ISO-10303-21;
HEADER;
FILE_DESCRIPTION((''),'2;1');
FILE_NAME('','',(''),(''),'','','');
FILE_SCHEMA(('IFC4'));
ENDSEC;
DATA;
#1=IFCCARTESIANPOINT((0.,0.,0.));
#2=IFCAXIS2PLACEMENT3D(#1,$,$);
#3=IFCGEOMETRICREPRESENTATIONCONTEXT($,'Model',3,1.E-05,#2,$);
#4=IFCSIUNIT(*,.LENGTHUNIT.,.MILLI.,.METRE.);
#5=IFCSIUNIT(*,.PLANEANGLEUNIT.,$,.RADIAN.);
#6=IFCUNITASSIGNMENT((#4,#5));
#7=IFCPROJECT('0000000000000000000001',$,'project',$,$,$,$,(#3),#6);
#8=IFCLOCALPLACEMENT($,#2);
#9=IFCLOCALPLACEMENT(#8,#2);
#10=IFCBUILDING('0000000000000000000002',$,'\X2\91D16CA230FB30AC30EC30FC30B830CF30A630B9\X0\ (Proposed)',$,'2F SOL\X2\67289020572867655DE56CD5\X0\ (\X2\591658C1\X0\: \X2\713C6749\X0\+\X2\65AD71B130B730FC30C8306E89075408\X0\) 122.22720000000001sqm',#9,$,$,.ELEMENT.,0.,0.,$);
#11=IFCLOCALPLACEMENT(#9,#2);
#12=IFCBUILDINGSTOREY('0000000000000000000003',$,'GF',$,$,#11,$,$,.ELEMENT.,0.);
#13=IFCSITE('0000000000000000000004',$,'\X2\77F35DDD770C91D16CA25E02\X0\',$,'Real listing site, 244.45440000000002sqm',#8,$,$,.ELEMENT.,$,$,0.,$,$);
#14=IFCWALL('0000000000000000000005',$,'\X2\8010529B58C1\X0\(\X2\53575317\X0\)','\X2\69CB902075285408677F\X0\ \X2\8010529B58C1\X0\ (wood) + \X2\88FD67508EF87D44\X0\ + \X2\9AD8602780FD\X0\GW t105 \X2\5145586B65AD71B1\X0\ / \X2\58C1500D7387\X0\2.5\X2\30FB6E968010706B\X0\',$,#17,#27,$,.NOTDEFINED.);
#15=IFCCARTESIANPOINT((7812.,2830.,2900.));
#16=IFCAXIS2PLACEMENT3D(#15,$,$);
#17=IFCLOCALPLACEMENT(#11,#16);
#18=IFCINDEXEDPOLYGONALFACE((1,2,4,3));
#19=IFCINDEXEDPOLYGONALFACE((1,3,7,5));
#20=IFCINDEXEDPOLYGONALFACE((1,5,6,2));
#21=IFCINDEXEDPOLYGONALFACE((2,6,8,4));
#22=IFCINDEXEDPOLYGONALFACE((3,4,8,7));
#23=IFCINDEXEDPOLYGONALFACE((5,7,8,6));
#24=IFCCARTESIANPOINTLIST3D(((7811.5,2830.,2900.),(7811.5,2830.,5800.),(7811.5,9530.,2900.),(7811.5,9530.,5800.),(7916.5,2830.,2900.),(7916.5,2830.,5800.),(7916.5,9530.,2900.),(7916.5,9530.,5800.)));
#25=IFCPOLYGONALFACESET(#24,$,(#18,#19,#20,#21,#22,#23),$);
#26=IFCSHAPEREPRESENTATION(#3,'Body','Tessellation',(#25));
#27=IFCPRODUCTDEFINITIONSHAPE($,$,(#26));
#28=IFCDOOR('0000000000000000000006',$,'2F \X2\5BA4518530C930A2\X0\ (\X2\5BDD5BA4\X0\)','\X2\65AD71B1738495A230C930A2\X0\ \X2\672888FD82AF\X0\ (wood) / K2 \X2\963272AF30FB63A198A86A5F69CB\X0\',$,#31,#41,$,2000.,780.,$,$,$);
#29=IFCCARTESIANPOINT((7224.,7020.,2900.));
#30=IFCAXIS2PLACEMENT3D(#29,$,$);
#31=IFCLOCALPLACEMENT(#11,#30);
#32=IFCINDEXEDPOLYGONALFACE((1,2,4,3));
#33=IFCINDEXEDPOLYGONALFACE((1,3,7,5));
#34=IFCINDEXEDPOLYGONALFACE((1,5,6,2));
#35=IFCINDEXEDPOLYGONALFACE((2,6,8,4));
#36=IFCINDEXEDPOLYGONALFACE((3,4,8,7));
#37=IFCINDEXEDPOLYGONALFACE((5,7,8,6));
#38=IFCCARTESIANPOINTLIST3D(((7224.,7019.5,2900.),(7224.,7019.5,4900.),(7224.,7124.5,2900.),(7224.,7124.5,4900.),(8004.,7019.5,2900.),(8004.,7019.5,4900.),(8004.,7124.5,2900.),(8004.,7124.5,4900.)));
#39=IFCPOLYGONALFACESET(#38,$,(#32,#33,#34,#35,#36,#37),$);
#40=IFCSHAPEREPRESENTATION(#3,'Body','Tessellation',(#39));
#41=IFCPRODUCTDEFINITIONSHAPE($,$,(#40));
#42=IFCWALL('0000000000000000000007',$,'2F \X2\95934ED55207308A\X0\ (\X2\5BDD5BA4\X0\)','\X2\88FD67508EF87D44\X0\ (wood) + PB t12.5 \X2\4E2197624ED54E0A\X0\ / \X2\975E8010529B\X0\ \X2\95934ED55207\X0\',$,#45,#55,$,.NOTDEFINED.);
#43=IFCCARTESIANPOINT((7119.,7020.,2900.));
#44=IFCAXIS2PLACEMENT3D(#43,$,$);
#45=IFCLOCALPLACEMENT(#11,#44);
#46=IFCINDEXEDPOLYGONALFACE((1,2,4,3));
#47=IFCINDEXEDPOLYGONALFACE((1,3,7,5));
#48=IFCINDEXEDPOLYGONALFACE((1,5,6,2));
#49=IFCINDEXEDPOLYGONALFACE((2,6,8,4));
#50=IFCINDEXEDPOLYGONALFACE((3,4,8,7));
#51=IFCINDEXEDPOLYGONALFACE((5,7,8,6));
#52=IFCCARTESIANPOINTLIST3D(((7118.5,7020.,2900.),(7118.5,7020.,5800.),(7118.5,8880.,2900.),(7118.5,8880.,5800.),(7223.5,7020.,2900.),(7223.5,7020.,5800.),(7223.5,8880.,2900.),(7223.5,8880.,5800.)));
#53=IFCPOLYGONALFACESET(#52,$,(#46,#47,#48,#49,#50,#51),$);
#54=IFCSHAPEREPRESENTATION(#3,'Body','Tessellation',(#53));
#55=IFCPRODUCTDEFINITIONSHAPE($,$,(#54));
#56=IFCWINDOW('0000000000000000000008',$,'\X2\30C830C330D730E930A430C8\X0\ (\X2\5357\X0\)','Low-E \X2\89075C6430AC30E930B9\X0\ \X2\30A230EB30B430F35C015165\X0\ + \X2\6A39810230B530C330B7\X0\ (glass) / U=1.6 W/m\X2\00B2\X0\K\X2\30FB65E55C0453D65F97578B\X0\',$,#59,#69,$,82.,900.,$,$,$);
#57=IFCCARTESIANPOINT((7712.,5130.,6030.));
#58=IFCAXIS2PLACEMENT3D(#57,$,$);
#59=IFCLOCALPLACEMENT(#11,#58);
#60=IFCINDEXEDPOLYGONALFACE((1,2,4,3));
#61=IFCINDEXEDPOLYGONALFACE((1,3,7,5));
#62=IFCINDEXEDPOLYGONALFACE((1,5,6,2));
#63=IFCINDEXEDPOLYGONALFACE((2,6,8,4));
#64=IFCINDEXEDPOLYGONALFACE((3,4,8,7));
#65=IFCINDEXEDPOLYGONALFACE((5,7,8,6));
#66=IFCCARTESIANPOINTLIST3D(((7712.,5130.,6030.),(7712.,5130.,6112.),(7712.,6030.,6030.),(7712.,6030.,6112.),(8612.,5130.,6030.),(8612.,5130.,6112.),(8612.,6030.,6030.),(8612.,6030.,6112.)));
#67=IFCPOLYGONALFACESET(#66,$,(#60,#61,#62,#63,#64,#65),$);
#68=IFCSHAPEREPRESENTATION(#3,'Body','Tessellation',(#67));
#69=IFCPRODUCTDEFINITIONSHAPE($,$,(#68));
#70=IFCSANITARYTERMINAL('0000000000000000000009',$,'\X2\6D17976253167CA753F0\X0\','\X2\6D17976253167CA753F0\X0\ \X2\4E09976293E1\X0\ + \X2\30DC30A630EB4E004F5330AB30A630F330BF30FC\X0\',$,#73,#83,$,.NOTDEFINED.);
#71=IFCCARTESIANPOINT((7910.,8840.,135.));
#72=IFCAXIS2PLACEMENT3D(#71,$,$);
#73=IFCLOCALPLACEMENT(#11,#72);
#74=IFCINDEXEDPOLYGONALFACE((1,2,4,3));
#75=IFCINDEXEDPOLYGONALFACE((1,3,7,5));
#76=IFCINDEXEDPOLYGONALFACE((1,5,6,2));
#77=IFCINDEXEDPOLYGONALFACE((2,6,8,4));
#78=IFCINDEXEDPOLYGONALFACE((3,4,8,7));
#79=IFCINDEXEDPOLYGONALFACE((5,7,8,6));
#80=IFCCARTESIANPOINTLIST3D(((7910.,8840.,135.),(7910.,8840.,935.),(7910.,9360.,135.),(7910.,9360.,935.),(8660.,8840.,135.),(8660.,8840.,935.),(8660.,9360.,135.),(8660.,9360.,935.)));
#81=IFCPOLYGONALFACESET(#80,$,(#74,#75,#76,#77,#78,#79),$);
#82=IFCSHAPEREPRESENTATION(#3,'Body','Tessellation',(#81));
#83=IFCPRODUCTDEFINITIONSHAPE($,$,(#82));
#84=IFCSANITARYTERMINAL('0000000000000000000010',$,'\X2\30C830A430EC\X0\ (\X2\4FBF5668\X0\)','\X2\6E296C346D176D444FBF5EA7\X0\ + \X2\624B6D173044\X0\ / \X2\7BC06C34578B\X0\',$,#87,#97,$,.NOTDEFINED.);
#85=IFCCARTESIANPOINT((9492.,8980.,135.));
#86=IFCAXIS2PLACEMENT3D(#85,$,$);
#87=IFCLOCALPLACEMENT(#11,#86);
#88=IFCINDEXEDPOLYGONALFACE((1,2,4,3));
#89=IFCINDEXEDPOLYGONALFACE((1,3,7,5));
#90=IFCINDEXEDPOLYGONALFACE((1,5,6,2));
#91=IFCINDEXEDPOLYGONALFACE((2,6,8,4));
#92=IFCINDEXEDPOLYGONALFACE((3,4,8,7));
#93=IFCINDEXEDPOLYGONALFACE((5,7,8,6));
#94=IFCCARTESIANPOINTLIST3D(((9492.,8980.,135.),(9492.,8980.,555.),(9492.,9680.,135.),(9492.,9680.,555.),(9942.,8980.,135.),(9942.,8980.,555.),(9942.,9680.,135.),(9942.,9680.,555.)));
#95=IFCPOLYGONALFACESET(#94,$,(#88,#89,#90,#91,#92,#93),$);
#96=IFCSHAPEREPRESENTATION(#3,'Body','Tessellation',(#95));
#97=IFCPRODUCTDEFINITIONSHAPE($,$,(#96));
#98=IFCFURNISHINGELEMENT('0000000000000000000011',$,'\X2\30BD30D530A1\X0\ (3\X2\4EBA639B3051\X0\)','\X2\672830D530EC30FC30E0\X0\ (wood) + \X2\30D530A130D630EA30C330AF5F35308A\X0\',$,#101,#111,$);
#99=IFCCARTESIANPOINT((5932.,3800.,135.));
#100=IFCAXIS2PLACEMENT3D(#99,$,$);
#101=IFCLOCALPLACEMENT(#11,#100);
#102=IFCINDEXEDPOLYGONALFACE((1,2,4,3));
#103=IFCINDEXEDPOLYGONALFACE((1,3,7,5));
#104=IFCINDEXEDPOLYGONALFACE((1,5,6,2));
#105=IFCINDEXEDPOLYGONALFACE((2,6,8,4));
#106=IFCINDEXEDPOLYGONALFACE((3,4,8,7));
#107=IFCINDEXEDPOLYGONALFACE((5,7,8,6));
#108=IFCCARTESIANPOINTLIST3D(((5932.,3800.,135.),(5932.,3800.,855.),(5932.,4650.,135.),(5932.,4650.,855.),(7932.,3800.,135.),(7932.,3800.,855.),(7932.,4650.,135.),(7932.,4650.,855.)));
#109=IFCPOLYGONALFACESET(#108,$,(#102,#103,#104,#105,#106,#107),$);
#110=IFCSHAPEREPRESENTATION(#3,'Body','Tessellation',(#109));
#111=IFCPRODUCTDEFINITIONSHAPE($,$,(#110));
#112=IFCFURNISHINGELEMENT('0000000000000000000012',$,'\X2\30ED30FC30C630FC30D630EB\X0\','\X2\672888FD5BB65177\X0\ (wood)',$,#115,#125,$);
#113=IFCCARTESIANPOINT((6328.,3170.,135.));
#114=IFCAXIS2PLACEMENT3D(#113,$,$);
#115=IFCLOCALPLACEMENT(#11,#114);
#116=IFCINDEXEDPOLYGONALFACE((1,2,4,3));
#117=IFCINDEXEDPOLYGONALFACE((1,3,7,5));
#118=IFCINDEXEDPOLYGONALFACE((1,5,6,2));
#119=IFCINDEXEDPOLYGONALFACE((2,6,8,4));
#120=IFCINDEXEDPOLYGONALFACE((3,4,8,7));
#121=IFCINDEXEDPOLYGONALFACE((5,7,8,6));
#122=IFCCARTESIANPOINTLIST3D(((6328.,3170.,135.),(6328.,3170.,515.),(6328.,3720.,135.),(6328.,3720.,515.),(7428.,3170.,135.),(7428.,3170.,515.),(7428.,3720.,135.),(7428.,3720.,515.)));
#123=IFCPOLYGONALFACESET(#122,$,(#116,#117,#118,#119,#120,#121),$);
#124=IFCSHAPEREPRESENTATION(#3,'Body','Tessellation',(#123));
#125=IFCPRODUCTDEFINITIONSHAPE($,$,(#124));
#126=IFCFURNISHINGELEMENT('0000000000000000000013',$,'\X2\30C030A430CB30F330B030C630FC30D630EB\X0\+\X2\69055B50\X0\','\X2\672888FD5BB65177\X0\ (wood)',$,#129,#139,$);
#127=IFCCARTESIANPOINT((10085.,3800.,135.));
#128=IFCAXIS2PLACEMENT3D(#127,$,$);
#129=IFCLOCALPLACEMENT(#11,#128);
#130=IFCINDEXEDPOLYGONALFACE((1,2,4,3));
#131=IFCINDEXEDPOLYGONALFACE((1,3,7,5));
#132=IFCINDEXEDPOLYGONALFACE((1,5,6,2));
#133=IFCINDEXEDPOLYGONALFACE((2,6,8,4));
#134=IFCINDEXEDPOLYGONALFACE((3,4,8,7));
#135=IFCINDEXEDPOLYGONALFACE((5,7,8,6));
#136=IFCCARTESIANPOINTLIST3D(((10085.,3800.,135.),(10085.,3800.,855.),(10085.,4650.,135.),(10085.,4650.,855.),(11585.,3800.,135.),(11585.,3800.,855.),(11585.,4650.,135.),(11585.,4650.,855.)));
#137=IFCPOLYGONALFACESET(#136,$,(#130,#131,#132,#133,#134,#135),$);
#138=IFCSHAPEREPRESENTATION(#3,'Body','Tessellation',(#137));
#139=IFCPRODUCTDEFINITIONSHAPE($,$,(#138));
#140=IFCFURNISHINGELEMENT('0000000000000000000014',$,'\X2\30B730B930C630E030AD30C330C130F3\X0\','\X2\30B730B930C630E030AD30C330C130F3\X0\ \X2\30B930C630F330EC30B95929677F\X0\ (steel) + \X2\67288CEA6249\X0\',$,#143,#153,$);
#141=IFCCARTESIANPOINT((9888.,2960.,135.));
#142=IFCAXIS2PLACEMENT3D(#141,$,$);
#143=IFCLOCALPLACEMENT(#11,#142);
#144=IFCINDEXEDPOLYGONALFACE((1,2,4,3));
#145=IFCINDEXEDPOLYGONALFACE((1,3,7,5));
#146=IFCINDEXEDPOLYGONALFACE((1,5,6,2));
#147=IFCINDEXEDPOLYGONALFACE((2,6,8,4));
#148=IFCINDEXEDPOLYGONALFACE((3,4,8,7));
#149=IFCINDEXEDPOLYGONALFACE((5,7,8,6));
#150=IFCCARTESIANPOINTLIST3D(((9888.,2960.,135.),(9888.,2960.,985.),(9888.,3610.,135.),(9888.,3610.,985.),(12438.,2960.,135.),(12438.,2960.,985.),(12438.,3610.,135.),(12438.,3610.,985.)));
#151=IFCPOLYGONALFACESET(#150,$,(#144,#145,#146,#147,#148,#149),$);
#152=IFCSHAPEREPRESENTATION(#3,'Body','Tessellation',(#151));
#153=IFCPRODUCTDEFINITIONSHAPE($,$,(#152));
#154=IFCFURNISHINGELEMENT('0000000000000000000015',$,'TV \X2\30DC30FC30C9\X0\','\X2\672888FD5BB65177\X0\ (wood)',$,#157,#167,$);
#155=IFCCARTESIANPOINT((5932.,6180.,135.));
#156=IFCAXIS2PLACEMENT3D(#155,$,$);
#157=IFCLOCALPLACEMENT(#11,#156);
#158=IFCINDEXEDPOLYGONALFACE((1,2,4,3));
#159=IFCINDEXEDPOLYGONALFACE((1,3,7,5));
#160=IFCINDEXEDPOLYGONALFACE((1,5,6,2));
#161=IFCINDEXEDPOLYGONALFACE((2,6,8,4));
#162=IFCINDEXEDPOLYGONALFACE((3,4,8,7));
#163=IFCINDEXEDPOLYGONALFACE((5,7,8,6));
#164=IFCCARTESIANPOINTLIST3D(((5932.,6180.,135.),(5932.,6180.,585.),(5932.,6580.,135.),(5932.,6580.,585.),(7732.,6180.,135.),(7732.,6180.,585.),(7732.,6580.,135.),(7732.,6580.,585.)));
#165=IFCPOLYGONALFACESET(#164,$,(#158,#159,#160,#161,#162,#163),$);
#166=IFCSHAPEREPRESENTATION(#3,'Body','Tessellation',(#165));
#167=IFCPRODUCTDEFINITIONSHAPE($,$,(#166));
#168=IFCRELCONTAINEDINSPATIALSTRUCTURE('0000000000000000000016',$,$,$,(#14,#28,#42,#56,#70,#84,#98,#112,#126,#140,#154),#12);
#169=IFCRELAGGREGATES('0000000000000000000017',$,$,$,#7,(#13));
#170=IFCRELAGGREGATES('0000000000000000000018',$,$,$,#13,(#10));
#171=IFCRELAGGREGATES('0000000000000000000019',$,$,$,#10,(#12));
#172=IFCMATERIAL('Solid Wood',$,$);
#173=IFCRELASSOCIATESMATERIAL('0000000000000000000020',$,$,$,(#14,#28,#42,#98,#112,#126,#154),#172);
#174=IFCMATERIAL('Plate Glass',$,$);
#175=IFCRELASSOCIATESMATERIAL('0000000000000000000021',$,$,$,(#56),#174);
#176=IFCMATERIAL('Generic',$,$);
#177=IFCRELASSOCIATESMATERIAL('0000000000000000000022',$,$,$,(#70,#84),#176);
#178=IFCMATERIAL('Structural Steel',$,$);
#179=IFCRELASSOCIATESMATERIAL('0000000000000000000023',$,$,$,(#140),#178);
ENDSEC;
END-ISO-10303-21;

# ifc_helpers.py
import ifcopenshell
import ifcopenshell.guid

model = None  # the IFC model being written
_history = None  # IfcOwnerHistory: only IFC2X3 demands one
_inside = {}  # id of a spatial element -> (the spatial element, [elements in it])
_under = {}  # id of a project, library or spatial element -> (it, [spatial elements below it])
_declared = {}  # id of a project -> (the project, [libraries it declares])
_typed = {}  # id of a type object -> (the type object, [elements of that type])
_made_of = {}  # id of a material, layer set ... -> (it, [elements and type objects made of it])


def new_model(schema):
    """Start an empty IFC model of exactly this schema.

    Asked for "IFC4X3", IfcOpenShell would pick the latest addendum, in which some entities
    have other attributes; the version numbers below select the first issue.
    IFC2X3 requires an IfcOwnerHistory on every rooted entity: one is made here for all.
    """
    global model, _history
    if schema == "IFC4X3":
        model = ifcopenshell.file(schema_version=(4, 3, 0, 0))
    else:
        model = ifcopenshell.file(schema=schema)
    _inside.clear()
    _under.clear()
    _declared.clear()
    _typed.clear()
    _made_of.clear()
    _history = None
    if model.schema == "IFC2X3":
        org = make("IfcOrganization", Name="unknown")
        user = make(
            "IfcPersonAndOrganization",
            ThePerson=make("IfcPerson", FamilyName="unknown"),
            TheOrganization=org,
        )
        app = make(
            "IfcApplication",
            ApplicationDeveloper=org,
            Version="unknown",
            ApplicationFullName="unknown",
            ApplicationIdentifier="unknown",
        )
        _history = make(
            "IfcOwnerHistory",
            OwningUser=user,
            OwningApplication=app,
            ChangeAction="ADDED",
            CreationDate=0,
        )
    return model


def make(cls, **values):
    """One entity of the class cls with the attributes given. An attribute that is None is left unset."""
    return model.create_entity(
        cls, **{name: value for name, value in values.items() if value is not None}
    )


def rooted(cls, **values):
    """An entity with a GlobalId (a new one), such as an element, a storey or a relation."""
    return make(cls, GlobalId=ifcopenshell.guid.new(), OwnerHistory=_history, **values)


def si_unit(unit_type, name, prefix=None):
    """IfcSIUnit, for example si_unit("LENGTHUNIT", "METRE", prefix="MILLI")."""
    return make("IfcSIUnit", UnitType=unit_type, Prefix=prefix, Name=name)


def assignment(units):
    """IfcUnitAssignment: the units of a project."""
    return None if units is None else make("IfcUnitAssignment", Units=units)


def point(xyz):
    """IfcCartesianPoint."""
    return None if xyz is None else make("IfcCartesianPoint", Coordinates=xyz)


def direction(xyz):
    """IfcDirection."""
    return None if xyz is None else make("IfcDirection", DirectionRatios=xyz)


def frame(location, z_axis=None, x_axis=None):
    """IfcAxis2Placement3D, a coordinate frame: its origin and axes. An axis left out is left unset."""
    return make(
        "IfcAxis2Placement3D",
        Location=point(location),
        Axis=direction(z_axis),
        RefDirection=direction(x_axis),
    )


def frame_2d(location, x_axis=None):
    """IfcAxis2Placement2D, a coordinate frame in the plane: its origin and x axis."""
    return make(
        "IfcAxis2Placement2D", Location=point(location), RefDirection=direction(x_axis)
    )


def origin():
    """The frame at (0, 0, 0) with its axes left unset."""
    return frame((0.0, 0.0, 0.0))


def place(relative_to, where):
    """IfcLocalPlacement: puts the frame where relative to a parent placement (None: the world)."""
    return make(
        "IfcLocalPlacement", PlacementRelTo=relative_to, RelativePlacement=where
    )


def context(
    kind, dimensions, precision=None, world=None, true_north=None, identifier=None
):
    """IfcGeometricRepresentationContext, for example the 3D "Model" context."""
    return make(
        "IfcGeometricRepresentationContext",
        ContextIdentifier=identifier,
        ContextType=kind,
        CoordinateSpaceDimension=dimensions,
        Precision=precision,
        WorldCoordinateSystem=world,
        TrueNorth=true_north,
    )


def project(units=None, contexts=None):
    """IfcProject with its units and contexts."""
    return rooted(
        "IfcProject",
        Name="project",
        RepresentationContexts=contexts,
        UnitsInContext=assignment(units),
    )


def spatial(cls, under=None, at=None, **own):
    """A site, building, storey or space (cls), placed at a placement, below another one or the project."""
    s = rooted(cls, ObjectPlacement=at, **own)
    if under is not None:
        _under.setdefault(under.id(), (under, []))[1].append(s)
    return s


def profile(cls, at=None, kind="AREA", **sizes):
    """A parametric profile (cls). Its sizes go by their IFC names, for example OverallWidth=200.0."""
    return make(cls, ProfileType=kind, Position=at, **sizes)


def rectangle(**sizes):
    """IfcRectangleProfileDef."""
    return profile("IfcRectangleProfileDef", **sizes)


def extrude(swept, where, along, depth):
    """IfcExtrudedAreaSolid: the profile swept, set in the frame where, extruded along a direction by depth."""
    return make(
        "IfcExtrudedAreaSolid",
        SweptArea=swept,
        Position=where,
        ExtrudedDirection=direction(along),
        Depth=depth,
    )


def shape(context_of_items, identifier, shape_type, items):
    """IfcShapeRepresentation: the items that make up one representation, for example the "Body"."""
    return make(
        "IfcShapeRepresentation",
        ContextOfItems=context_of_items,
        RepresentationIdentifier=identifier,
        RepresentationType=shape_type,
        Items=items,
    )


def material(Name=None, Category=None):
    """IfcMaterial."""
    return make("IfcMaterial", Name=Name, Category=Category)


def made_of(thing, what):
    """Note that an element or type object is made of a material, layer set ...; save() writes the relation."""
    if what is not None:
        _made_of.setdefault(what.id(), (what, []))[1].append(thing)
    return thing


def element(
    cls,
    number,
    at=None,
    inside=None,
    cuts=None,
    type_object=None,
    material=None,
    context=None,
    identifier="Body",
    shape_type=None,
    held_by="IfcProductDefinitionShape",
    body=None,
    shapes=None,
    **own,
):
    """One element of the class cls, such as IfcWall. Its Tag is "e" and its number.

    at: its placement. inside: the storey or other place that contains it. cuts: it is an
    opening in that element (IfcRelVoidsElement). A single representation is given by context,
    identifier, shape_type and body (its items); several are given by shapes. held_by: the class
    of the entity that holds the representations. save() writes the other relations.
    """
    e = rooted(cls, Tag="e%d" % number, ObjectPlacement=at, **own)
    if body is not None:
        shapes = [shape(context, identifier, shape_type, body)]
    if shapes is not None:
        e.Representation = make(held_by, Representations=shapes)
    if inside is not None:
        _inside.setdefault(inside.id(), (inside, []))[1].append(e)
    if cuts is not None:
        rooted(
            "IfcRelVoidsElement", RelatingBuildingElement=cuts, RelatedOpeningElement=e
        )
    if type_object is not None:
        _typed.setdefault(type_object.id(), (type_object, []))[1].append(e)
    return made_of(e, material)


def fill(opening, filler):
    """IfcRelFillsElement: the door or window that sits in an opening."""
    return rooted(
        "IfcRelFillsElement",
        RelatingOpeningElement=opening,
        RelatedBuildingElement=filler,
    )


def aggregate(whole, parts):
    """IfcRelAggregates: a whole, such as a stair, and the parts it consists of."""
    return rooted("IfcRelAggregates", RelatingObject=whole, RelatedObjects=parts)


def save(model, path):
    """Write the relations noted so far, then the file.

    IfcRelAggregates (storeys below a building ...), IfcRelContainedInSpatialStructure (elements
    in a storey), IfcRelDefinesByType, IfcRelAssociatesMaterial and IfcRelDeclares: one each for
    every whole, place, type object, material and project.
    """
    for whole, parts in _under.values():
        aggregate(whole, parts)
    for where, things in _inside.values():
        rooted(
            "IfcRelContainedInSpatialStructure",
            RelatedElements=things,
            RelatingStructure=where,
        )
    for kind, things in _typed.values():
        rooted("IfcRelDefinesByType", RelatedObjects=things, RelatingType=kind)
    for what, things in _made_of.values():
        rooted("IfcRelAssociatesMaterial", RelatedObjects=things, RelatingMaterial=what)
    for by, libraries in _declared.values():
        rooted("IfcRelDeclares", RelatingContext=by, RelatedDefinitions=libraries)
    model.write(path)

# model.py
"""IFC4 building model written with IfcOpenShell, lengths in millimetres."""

from ifc_helpers import new_model, si_unit, frame, frame_2d, origin, place, context, project, spatial, rectangle, extrude, material, element, fill, save


model = new_model("IFC4")

# Units and contexts
model_context = context("Model", 3, precision=1e-05, world=origin())
ifc_project = project(units=[si_unit("LENGTHUNIT", "METRE", prefix="MILLI"), si_unit("PLANEANGLEUNIT", "RADIAN")], contexts=[model_context])

# Site, building, storey
site_placement = place(None, origin())
site = spatial("IfcSite", under=ifc_project, at=site_placement, Name="石川県金沢市", ObjectType="Real listing site, 244.45440000000002sqm", CompositionType="ELEMENT", RefElevation=0.0)
building_placement = place(site_placement, origin())
building = spatial("IfcBuilding", under=site, at=building_placement, Name="金沢・ガレージハウス (Proposed)", ObjectType="2F SOL木造在来工法 (外壁: 焼杉+断熱シートの複合) 122.22720000000001sqm", CompositionType="ELEMENT", ElevationOfRefHeight=0.0, ElevationOfTerrain=0.0)
storey_placement = place(building_placement, origin())
storey = spatial("IfcBuildingStorey", under=building, at=storey_placement, Name="GF", CompositionType="ELEMENT", Elevation=0.0)

# Shared definitions
ifc_material_1 = material(Name="Solid Wood")

# Wall, opening, door
wall_1_placement = place(storey_placement, frame((7812.0, 2830.0, 2900.0)))
wall_1 = element("IfcWall", 1, at=wall_1_placement, inside=storey, material=ifc_material_1, Name="耐力壁(南北)", Description="構造用合板 耐力壁 (wood) + 製材軸組 + 高性能GW t105 充填断熱 / 壁倍率2.5・準耐火", PredefinedType="NOTDEFINED", context=model_context, shape_type="SweptSolid", body=[
    extrude(rectangle(XDim=105.0, YDim=6700.0, at=frame_2d((52.0, 3350.0))), frame((7812.0, 2830.0, 2900.0)), (0.0, 0.0, 1.0), 2900.0),
])
opening_1_placement = place(storey_placement, frame((7224.0, 7020.0, 2900.0)))
opening_1 = element("IfcOpeningElement", 2, at=opening_1_placement, cuts=wall_1, PredefinedType="NOTDEFINED", context=model_context, shape_type="SweptSolid", body=[
    extrude(rectangle(XDim=780.0, YDim=105.0, at=frame_2d((390.0, 52.0))), frame((7224.0, 7020.0, 2900.0)), (0.0, 0.0, 1.0), 2000.0),
])
door_1_placement = place(storey_placement, frame((7224.0, 7020.0, 2900.0)))
door_1 = element("IfcDoor", 3, at=door_1_placement, inside=storey, material=ifc_material_1, Name="2F 室内ドア (寝室)", Description="断熱玄関ドア 木製芯 (wood) / K2 防犯・採風機構", OverallHeight=2000.0, OverallWidth=780.0, context=model_context, shape_type="SweptSolid", body=[
    extrude(rectangle(XDim=780.0, YDim=105.0, at=frame_2d((390.0, 52.0))), frame((7224.0, 7020.0, 2900.0)), (0.0, 0.0, 1.0), 2000.0),
])
fill(opening_1, door_1)

# Wall
wall_2_placement = place(storey_placement, frame((7119.0, 7020.0, 2900.0)))
element("IfcWall", 4, at=wall_2_placement, inside=storey, material=ifc_material_1, Name="2F 間仕切り (寝室)", Description="製材軸組 (wood) + PB t12.5 両面仕上 / 非耐力 間仕切", PredefinedType="NOTDEFINED", context=model_context, shape_type="SweptSolid", body=[
    extrude(rectangle(XDim=105.0, YDim=1860.0, at=frame_2d((52.0, 930.0))), frame((7119.0, 7020.0, 2900.0)), (0.0, 0.0, 1.0), 2900.0),
])

# Window
ifc_material_2 = material(Name="Plate Glass")
window_placement = place(storey_placement, frame((7712.0, 5130.0, 6030.0)))
element("IfcWindow", 5, at=window_placement, inside=storey, material=ifc_material_2, Name="トップライト (南)", Description="Low-E 複層ガラス アルゴン封入 + 樹脂サッシ (glass) / U=1.6 W/m²K・日射取得型", OverallHeight=82.0, OverallWidth=900.0, context=model_context, shape_type="SweptSolid", body=[
    extrude(rectangle(XDim=900.0, YDim=900.0, at=frame_2d((450.0, 450.0))), frame((7712.0, 5130.0, 6030.0)), (0.0, 0.0, 1.0), 82.0),
])

# Sanitary terminals
ifc_material_3 = material(Name="Generic")
sanitary_terminal_1_placement = place(storey_placement, frame((7910.0, 8840.0, 135.0)))
element("IfcSanitaryTerminal", 6, at=sanitary_terminal_1_placement, inside=storey, material=ifc_material_3, Name="洗面化粧台", Description="洗面化粧台 三面鏡 + ボウル一体カウンター", PredefinedType="NOTDEFINED", context=model_context, shape_type="SweptSolid", body=[
    extrude(rectangle(XDim=750.0, YDim=520.0, at=frame_2d((375.0, 260.0))), frame((7910.0, 8840.0, 135.0)), (0.0, 0.0, 1.0), 800.0),
])
sanitary_terminal_2_placement = place(storey_placement, frame((9492.0, 8980.0, 135.0)))
element("IfcSanitaryTerminal", 7, at=sanitary_terminal_2_placement, inside=storey, material=ifc_material_3, Name="トイレ (便器)", Description="温水洗浄便座 + 手洗い / 節水型", PredefinedType="NOTDEFINED", context=model_context, shape_type="SweptSolid", body=[
    extrude(rectangle(XDim=450.0, YDim=700.0, at=frame_2d((225.0, 350.0))), frame((9492.0, 8980.0, 135.0)), (0.0, 0.0, 1.0), 420.0),
])

# Furnishing elements
furnishing_1_placement = place(storey_placement, frame((5932.0, 3800.0, 135.0)))
element("IfcFurnishingElement", 8, at=furnishing_1_placement, inside=storey, material=ifc_material_1, Name="ソファ (3人掛け)", Description="木フレーム (wood) + ファブリック張り", context=model_context, shape_type="SweptSolid", body=[
    extrude(rectangle(XDim=2000.0, YDim=850.0, at=frame_2d((1000.0, 425.0))), frame((5932.0, 3800.0, 135.0)), (0.0, 0.0, 1.0), 720.0),
])
furnishing_2_placement = place(storey_placement, frame((6328.0, 3170.0, 135.0)))
element("IfcFurnishingElement", 9, at=furnishing_2_placement, inside=storey, material=ifc_material_1, Name="ローテーブル", Description="木製家具 (wood)", context=model_context, shape_type="SweptSolid", body=[
    extrude(rectangle(XDim=1100.0, YDim=550.0, at=frame_2d((550.0, 275.0))), frame((6328.0, 3170.0, 135.0)), (0.0, 0.0, 1.0), 380.0),
])
furnishing_3_placement = place(storey_placement, frame((10085.0, 3800.0, 135.0)))
element("IfcFurnishingElement", 10, at=furnishing_3_placement, inside=storey, material=ifc_material_1, Name="ダイニングテーブル+椅子", Description="木製家具 (wood)", context=model_context, shape_type="SweptSolid", body=[
    extrude(rectangle(XDim=1500.0, YDim=850.0, at=frame_2d((750.0, 425.0))), frame((10085.0, 3800.0, 135.0)), (0.0, 0.0, 1.0), 720.0),
])
ifc_material_4 = material(Name="Structural Steel")
furnishing_4_placement = place(storey_placement, frame((9888.0, 2960.0, 135.0)))
element("IfcFurnishingElement", 11, at=furnishing_4_placement, inside=storey, material=ifc_material_4, Name="システムキッチン", Description="システムキッチン ステンレス天板 (steel) + 木質扉", context=model_context, shape_type="SweptSolid", body=[
    extrude(rectangle(XDim=2550.0, YDim=650.0, at=frame_2d((1275.0, 325.0))), frame((9888.0, 2960.0, 135.0)), (0.0, 0.0, 1.0), 850.0),
])
furnishing_5_placement = place(storey_placement, frame((5932.0, 6180.0, 135.0)))
element("IfcFurnishingElement", 12, at=furnishing_5_placement, inside=storey, material=ifc_material_1, Name="TV ボード", Description="木製家具 (wood)", context=model_context, shape_type="SweptSolid", body=[
    extrude(rectangle(XDim=1800.0, YDim=400.0, at=frame_2d((900.0, 200.0))), frame((5932.0, 6180.0, 135.0)), (0.0, 0.0, 1.0), 450.0),
])

save(model, "model.ifc")
